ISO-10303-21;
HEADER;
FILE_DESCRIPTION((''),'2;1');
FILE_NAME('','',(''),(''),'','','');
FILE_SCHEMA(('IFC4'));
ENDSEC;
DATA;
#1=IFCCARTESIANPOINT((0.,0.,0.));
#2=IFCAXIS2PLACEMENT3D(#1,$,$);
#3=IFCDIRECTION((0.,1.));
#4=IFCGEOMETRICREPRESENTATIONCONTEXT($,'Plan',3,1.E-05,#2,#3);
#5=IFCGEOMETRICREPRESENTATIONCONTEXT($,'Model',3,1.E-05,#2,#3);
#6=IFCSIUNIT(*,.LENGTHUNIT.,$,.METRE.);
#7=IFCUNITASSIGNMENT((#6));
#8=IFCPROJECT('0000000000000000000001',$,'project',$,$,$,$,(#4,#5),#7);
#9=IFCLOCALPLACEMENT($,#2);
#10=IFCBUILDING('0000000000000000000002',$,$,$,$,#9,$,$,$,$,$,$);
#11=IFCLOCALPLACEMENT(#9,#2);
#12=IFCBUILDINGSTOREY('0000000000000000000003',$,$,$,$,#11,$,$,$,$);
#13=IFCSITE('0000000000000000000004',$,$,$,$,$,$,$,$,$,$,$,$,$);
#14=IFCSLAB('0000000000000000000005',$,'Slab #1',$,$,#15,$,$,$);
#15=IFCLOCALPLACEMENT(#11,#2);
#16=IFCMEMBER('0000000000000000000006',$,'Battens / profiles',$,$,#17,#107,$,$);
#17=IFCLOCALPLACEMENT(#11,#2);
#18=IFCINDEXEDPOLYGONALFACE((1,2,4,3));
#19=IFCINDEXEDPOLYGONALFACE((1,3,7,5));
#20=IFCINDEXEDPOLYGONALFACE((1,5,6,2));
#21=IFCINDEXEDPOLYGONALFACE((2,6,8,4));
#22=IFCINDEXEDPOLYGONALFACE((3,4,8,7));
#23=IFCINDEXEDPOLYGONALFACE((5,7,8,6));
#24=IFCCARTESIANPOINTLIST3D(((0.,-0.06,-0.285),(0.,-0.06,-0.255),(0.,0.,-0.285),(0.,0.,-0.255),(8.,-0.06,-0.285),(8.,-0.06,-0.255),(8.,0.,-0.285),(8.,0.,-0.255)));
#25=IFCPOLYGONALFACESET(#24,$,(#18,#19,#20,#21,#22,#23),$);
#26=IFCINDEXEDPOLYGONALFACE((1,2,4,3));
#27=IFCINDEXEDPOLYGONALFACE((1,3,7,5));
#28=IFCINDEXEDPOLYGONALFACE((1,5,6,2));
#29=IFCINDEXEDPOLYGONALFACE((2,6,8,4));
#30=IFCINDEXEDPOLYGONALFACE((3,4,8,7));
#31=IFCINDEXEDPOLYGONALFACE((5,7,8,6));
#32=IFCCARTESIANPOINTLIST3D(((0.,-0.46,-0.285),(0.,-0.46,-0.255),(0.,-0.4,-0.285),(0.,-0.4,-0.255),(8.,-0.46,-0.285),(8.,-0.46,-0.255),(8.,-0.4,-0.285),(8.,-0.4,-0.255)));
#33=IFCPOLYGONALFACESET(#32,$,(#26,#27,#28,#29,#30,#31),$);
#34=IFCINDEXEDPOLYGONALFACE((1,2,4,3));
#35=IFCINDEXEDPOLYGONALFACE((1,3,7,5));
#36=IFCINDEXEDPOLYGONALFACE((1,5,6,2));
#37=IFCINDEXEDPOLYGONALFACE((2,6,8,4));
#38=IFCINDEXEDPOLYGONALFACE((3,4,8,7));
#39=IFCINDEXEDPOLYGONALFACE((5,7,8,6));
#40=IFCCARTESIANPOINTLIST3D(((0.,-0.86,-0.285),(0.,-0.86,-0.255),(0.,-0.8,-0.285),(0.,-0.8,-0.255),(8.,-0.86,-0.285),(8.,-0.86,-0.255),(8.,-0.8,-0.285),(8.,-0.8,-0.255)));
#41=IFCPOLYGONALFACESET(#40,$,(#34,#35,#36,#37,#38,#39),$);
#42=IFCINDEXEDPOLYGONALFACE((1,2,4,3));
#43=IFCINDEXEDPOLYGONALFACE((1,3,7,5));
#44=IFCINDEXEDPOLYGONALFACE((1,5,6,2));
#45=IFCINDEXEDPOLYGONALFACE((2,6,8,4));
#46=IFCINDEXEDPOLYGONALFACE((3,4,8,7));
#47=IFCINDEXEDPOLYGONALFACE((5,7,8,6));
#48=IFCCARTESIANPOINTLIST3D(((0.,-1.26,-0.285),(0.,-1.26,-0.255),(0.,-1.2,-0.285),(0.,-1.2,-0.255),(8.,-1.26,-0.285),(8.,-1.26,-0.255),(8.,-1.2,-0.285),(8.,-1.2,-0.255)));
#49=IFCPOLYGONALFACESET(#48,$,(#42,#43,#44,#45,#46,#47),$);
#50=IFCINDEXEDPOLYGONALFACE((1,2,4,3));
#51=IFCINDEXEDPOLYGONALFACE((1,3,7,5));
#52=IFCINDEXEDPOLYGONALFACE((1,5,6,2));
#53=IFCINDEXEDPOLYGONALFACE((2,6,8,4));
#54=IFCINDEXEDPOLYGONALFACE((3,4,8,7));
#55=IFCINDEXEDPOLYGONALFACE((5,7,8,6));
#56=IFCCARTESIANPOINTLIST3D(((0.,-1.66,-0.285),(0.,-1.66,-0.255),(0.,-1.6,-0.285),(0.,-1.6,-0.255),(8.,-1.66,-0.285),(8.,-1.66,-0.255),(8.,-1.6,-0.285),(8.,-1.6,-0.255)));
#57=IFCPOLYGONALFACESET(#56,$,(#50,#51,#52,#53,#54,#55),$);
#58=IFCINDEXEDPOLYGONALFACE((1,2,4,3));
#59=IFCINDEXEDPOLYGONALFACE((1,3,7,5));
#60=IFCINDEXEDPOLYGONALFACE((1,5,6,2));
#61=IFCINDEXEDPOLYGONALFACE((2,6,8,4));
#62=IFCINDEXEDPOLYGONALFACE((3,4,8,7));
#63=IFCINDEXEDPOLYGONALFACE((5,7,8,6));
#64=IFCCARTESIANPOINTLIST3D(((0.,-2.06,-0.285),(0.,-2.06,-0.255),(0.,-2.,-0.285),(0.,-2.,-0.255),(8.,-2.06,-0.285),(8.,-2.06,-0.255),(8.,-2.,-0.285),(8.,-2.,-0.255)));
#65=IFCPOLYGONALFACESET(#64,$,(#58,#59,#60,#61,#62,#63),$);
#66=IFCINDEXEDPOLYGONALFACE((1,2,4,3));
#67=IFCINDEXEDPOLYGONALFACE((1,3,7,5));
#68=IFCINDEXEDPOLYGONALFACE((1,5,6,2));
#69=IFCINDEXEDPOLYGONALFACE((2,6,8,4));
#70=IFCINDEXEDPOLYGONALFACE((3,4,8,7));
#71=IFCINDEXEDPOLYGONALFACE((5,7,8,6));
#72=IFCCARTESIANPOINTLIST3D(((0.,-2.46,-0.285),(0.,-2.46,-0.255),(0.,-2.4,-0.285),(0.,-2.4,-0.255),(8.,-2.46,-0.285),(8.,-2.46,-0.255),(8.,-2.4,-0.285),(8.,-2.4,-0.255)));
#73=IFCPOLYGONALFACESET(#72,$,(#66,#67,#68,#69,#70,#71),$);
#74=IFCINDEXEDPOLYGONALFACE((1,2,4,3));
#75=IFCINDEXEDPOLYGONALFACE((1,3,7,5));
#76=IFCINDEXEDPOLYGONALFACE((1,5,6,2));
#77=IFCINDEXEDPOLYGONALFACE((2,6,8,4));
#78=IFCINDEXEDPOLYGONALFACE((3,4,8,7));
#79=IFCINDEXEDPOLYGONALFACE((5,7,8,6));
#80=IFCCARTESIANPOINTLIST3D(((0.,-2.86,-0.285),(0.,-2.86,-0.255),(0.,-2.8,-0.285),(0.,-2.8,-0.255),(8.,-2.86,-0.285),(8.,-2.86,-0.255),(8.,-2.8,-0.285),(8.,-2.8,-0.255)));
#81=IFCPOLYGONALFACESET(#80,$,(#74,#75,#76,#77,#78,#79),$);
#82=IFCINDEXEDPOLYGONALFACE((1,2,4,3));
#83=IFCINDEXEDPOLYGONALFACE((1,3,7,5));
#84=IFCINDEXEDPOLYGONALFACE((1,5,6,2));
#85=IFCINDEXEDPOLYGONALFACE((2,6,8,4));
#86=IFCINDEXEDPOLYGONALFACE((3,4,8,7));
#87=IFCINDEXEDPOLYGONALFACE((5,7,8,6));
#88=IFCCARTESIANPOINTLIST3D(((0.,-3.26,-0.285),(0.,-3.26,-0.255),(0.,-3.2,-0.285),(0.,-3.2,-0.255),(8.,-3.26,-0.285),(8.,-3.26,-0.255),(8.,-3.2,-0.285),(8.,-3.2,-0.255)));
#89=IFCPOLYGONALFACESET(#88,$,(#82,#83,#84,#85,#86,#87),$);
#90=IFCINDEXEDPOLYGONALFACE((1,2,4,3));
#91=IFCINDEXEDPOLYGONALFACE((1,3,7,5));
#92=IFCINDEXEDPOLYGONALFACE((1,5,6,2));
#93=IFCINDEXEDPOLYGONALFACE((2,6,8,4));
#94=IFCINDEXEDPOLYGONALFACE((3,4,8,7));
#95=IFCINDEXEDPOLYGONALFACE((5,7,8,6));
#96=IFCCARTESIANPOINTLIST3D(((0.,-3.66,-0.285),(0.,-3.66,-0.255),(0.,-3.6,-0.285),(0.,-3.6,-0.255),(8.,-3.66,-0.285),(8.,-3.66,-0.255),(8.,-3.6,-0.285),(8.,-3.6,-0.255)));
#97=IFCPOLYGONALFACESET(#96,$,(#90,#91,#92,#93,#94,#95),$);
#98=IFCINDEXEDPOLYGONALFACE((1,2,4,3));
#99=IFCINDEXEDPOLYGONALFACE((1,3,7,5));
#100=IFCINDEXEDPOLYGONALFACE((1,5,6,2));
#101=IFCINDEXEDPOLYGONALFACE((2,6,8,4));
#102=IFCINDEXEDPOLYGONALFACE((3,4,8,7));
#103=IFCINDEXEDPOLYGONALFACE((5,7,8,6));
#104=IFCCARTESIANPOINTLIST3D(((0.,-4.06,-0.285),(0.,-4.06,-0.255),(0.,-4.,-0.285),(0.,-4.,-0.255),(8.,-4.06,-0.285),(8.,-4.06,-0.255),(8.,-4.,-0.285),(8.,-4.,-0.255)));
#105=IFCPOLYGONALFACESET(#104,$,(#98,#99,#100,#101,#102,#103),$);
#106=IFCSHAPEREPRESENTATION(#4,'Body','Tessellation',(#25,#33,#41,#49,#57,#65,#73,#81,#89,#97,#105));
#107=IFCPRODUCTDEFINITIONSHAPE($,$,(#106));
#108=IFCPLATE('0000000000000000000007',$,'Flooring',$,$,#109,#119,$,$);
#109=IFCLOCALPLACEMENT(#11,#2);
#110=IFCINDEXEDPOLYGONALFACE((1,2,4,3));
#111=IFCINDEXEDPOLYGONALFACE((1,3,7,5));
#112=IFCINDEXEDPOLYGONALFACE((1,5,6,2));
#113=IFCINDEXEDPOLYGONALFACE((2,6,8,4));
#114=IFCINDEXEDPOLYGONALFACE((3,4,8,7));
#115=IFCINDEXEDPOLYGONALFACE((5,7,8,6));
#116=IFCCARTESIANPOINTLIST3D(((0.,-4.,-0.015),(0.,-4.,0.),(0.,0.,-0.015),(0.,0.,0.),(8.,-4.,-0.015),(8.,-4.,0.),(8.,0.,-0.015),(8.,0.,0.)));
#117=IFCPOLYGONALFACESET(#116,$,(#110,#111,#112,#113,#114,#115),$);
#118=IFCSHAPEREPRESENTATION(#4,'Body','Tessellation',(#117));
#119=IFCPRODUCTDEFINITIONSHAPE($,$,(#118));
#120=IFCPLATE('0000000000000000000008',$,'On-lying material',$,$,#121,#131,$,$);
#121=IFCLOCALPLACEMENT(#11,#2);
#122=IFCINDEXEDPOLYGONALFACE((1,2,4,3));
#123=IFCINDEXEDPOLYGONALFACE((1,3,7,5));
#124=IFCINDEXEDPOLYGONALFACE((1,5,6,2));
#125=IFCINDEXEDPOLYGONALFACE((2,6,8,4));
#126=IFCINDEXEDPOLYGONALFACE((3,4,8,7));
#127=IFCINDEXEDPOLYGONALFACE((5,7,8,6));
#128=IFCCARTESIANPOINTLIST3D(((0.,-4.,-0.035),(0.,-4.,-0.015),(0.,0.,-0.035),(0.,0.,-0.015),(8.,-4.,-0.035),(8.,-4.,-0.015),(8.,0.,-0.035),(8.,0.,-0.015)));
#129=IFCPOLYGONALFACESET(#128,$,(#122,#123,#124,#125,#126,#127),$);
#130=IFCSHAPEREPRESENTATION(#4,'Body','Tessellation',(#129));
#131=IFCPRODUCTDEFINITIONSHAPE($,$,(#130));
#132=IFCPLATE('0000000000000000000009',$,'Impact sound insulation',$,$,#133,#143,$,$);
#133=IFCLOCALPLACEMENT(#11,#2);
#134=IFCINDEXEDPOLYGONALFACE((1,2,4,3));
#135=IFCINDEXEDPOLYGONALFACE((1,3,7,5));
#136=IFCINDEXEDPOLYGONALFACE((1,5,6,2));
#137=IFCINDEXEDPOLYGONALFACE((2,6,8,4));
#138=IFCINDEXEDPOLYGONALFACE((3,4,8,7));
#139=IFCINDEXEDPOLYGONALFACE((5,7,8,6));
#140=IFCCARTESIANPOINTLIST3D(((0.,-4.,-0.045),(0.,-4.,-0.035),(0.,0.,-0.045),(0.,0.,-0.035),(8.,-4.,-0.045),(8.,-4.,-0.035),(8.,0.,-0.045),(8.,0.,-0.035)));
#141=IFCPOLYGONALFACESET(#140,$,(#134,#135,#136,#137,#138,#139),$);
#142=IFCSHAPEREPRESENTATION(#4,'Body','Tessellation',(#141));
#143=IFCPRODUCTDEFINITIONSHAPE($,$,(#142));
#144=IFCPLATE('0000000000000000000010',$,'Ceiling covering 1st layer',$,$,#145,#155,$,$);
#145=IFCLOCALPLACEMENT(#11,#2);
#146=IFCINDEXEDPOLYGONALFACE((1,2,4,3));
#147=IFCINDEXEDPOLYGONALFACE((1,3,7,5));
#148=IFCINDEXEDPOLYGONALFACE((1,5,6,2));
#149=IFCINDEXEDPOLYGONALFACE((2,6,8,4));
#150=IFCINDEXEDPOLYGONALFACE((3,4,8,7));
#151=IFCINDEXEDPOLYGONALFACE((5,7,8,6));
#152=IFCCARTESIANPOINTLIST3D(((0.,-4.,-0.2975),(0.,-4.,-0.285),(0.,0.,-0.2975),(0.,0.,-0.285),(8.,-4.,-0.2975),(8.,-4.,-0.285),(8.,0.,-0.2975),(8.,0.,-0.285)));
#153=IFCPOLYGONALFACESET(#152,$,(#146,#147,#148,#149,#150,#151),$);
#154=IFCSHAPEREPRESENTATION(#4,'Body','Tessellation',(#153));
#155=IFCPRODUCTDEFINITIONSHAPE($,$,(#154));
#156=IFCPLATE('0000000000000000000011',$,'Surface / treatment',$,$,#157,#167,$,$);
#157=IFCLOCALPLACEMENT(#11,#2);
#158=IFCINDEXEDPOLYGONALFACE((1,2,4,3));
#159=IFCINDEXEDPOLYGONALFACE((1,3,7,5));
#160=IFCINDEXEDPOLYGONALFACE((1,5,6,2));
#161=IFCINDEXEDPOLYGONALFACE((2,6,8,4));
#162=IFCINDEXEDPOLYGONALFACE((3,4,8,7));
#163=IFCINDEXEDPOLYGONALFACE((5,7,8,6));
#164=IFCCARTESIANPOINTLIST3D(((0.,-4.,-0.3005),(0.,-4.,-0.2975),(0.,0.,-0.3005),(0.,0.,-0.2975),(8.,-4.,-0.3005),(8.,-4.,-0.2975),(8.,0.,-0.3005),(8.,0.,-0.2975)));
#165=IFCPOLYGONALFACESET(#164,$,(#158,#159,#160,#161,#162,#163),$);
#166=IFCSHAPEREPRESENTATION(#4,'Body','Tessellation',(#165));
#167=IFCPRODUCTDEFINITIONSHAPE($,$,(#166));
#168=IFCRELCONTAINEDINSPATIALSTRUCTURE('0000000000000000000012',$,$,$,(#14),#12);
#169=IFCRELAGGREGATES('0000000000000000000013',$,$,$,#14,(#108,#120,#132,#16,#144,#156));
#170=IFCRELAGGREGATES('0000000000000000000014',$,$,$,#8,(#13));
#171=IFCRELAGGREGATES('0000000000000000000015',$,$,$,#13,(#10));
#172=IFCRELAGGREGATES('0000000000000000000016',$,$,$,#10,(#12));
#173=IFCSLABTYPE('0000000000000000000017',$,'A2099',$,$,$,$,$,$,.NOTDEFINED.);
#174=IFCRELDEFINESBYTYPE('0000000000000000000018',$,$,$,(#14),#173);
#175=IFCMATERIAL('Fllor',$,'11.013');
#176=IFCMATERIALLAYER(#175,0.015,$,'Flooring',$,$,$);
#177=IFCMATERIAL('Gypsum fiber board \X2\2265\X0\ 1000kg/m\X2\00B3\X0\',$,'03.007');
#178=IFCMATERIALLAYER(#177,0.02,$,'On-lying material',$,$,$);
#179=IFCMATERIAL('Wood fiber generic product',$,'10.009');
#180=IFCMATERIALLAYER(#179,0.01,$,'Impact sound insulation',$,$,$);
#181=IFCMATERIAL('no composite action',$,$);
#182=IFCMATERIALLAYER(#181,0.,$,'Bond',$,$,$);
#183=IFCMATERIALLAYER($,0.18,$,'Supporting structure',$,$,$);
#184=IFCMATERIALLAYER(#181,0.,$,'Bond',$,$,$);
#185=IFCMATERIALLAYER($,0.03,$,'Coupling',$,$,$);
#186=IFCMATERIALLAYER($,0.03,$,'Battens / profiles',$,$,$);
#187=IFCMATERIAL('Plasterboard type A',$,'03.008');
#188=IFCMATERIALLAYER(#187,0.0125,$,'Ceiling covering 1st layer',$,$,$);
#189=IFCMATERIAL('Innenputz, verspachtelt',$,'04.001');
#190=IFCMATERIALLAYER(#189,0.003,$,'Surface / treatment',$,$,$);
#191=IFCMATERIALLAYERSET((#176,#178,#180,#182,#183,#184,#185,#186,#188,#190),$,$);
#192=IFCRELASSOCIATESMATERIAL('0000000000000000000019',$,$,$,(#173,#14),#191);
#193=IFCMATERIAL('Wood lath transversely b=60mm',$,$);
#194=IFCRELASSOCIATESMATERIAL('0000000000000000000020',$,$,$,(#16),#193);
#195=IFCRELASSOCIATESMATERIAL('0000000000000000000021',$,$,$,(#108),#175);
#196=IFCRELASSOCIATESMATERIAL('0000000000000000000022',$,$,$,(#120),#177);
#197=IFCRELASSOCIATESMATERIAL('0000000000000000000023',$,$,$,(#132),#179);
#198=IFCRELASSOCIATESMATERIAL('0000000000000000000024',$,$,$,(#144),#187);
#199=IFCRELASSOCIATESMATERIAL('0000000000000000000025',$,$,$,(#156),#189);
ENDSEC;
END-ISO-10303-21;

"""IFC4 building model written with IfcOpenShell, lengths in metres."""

from ifc_helpers import new_model, si_unit, direction, frame, frame_2d, origin, origin_with_axes, place, context, project, spatial, rectangle, extrude, material, layer, layer_set, type_object, element, aggregate, save


model = new_model("IFC4")

# Units and contexts
plan_context = context("Plan", 3, precision=1e-05, world=origin(), true_north=direction((0.0, 1.0)))
model_context = context("Model", 3, precision=1e-05, world=origin(), true_north=direction((0.0, 1.0)))
ifc_project = project(units=[si_unit("LENGTHUNIT", "METRE")], contexts=[plan_context, model_context])

# Site, building, storey
site = spatial("IfcSite", under=ifc_project)
building_placement = place(None, origin())
building = spatial("IfcBuilding", under=site, at=building_placement)
storey_placement = place(building_placement, origin())
storey = spatial("IfcBuildingStorey", under=building, at=storey_placement)

# Slab, member, plates
ifc_material_1 = material(Name="Fllor", Category="11.013")
ifc_layer_1 = layer(ifc_material_1, 0.015, Name="Flooring")
ifc_material_2 = material(Name="Gypsum fiber board ≥ 1000kg/m³", Category="03.007")
ifc_layer_2 = layer(ifc_material_2, 0.02, Name="On-lying material")
ifc_material_3 = material(Name="Wood fiber generic product", Category="10.009")
ifc_layer_3 = layer(ifc_material_3, 0.01, Name="Impact sound insulation")
ifc_material_4 = material(Name="no composite action")
ifc_layer_4 = layer(ifc_material_4, 0.0, Name="Bond")
ifc_layer_5 = layer(None, 0.18, Name="Supporting structure")
ifc_layer_6 = layer(ifc_material_4, 0.0, Name="Bond")
ifc_layer_7 = layer(None, 0.03, Name="Coupling")
ifc_layer_8 = layer(None, 0.03, Name="Battens / profiles")
ifc_material_5 = material(Name="Plasterboard type A", Category="03.008")
ifc_layer_9 = layer(ifc_material_5, 0.0125, Name="Ceiling covering 1st layer")
ifc_material_6 = material(Name="Innenputz, verspachtelt", Category="04.001")
ifc_layer_10 = layer(ifc_material_6, 0.003, Name="Surface / treatment")
ifc_layer_set = layer_set([ifc_layer_1, ifc_layer_2, ifc_layer_3, ifc_layer_4, ifc_layer_5, ifc_layer_6, ifc_layer_7, ifc_layer_8, ifc_layer_9, ifc_layer_10])
slab_type = type_object("IfcSlabType", Name="A2099", PredefinedType="NOTDEFINED", material=ifc_layer_set)
slab_placement = place(None, frame((0.0, 0.0, 0.0), z_axis=(0.0, 0.0, -1.0), x_axis=(1.0, 0.0, 0.0)))
slab = element("IfcSlab", 1, at=slab_placement, inside=storey, type_object=slab_type, material=ifc_layer_set, Name="Slab #1")
ifc_material_7 = material(Name="Wood lath transversely b=60mm")
member_1_placement = place(slab_placement, origin())
member_1 = element("IfcMember", 2, at=member_1_placement, material=ifc_material_7, Name="Battens / profiles", context=plan_context, shape_type="SweptSolid", body=[
    extrude(rectangle(XDim=0.06, YDim=0.03, at=frame_2d((0.03, 0.015), x_axis=(1.0, 0.0))), frame((0.0, 0.0, 0.255), z_axis=(1.0, 0.0, 0.0), x_axis=(0.0, 1.0, 0.0)), (0.0, 0.0, 1.0), 8.0),
    extrude(rectangle(XDim=0.06, YDim=0.03, at=frame_2d((0.03, 0.015), x_axis=(1.0, 0.0))), frame((0.0, 0.4, 0.255), z_axis=(1.0, 0.0, 0.0), x_axis=(0.0, 1.0, 0.0)), (0.0, 0.0, 1.0), 8.0),
    extrude(rectangle(XDim=0.06, YDim=0.03, at=frame_2d((0.03, 0.015), x_axis=(1.0, 0.0))), frame((0.0, 0.8, 0.255), z_axis=(1.0, 0.0, 0.0), x_axis=(0.0, 1.0, 0.0)), (0.0, 0.0, 1.0), 8.0),
    extrude(rectangle(XDim=0.06, YDim=0.03, at=frame_2d((0.03, 0.015), x_axis=(1.0, 0.0))), frame((0.0, 1.2, 0.255), z_axis=(1.0, 0.0, 0.0), x_axis=(0.0, 1.0, 0.0)), (0.0, 0.0, 1.0), 8.0),
    extrude(rectangle(XDim=0.06, YDim=0.03, at=frame_2d((0.03, 0.015), x_axis=(1.0, 0.0))), frame((0.0, 1.6, 0.255), z_axis=(1.0, 0.0, 0.0), x_axis=(0.0, 1.0, 0.0)), (0.0, 0.0, 1.0), 8.0),
    extrude(rectangle(XDim=0.06, YDim=0.03, at=frame_2d((0.03, 0.015), x_axis=(1.0, 0.0))), frame((0.0, 2.0, 0.255), z_axis=(1.0, 0.0, 0.0), x_axis=(0.0, 1.0, 0.0)), (0.0, 0.0, 1.0), 8.0),
    extrude(rectangle(XDim=0.06, YDim=0.03, at=frame_2d((0.03, 0.015), x_axis=(1.0, 0.0))), frame((0.0, 2.4, 0.255), z_axis=(1.0, 0.0, 0.0), x_axis=(0.0, 1.0, 0.0)), (0.0, 0.0, 1.0), 8.0),
    extrude(rectangle(XDim=0.06, YDim=0.03, at=frame_2d((0.03, 0.015), x_axis=(1.0, 0.0))), frame((0.0, 2.8, 0.255), z_axis=(1.0, 0.0, 0.0), x_axis=(0.0, 1.0, 0.0)), (0.0, 0.0, 1.0), 8.0),
    extrude(rectangle(XDim=0.06, YDim=0.03, at=frame_2d((0.03, 0.015), x_axis=(1.0, 0.0))), frame((0.0, 3.2, 0.255), z_axis=(1.0, 0.0, 0.0), x_axis=(0.0, 1.0, 0.0)), (0.0, 0.0, 1.0), 8.0),
    extrude(rectangle(XDim=0.06, YDim=0.03, at=frame_2d((0.03, 0.015), x_axis=(1.0, 0.0))), frame((0.0, 3.6, 0.255), z_axis=(1.0, 0.0, 0.0), x_axis=(0.0, 1.0, 0.0)), (0.0, 0.0, 1.0), 8.0),
    extrude(rectangle(XDim=0.06, YDim=0.03, at=frame_2d((0.03, 0.015), x_axis=(1.0, 0.0))), frame((0.0, 4.0, 0.255), z_axis=(1.0, 0.0, 0.0), x_axis=(0.0, 1.0, 0.0)), (0.0, 0.0, 1.0), 8.0),
])
plate_1_placement = place(slab_placement, origin())
plate_1 = element("IfcPlate", 3, at=plate_1_placement, material=ifc_material_1, Name="Flooring", context=plan_context, shape_type="SweptSolid", body=[
    extrude(rectangle(XDim=8.0, YDim=4.0, at=frame_2d((4.0, 2.0), x_axis=(1.0, 0.0))), origin_with_axes(), (0.0, 0.0, 1.0), 0.015),
])
plate_2_placement = place(slab_placement, origin())
plate_2 = element("IfcPlate", 4, at=plate_2_placement, material=ifc_material_2, Name="On-lying material", context=plan_context, shape_type="SweptSolid", body=[
    extrude(rectangle(XDim=8.0, YDim=4.0, at=frame_2d((4.0, 2.0), x_axis=(1.0, 0.0))), frame((0.0, 0.0, 0.015), z_axis=(0.0, 0.0, 1.0), x_axis=(1.0, 0.0, 0.0)), (0.0, 0.0, 1.0), 0.02),
])
plate_3_placement = place(slab_placement, origin())
plate_3 = element("IfcPlate", 5, at=plate_3_placement, material=ifc_material_3, Name="Impact sound insulation", context=plan_context, shape_type="SweptSolid", body=[
    extrude(rectangle(XDim=8.0, YDim=4.0, at=frame_2d((4.0, 2.0), x_axis=(1.0, 0.0))), frame((0.0, 0.0, 0.035), z_axis=(0.0, 0.0, 1.0), x_axis=(1.0, 0.0, 0.0)), (0.0, 0.0, 1.0), 0.01),
])
plate_4_placement = place(slab_placement, origin())
plate_4 = element("IfcPlate", 6, at=plate_4_placement, material=ifc_material_5, Name="Ceiling covering 1st layer", context=plan_context, shape_type="SweptSolid", body=[
    extrude(rectangle(XDim=8.0, YDim=4.0, at=frame_2d((4.0, 2.0), x_axis=(1.0, 0.0))), frame((0.0, 0.0, 0.285), z_axis=(0.0, 0.0, 1.0), x_axis=(1.0, 0.0, 0.0)), (0.0, 0.0, 1.0), 0.0125),
])
plate_5_placement = place(slab_placement, origin())
plate_5 = element("IfcPlate", 7, at=plate_5_placement, material=ifc_material_6, Name="Surface / treatment", context=plan_context, shape_type="SweptSolid", body=[
    extrude(rectangle(XDim=8.0, YDim=4.0, at=frame_2d((4.0, 2.0), x_axis=(1.0, 0.0))), frame((0.0, 0.0, 0.2975), z_axis=(0.0, 0.0, 1.0), x_axis=(1.0, 0.0, 0.0)), (0.0, 0.0, 1.0), 0.003),
])
aggregate(slab, [plate_1, plate_2, plate_3, member_1, plate_4, plate_5])

save(model, "model.ifc")
